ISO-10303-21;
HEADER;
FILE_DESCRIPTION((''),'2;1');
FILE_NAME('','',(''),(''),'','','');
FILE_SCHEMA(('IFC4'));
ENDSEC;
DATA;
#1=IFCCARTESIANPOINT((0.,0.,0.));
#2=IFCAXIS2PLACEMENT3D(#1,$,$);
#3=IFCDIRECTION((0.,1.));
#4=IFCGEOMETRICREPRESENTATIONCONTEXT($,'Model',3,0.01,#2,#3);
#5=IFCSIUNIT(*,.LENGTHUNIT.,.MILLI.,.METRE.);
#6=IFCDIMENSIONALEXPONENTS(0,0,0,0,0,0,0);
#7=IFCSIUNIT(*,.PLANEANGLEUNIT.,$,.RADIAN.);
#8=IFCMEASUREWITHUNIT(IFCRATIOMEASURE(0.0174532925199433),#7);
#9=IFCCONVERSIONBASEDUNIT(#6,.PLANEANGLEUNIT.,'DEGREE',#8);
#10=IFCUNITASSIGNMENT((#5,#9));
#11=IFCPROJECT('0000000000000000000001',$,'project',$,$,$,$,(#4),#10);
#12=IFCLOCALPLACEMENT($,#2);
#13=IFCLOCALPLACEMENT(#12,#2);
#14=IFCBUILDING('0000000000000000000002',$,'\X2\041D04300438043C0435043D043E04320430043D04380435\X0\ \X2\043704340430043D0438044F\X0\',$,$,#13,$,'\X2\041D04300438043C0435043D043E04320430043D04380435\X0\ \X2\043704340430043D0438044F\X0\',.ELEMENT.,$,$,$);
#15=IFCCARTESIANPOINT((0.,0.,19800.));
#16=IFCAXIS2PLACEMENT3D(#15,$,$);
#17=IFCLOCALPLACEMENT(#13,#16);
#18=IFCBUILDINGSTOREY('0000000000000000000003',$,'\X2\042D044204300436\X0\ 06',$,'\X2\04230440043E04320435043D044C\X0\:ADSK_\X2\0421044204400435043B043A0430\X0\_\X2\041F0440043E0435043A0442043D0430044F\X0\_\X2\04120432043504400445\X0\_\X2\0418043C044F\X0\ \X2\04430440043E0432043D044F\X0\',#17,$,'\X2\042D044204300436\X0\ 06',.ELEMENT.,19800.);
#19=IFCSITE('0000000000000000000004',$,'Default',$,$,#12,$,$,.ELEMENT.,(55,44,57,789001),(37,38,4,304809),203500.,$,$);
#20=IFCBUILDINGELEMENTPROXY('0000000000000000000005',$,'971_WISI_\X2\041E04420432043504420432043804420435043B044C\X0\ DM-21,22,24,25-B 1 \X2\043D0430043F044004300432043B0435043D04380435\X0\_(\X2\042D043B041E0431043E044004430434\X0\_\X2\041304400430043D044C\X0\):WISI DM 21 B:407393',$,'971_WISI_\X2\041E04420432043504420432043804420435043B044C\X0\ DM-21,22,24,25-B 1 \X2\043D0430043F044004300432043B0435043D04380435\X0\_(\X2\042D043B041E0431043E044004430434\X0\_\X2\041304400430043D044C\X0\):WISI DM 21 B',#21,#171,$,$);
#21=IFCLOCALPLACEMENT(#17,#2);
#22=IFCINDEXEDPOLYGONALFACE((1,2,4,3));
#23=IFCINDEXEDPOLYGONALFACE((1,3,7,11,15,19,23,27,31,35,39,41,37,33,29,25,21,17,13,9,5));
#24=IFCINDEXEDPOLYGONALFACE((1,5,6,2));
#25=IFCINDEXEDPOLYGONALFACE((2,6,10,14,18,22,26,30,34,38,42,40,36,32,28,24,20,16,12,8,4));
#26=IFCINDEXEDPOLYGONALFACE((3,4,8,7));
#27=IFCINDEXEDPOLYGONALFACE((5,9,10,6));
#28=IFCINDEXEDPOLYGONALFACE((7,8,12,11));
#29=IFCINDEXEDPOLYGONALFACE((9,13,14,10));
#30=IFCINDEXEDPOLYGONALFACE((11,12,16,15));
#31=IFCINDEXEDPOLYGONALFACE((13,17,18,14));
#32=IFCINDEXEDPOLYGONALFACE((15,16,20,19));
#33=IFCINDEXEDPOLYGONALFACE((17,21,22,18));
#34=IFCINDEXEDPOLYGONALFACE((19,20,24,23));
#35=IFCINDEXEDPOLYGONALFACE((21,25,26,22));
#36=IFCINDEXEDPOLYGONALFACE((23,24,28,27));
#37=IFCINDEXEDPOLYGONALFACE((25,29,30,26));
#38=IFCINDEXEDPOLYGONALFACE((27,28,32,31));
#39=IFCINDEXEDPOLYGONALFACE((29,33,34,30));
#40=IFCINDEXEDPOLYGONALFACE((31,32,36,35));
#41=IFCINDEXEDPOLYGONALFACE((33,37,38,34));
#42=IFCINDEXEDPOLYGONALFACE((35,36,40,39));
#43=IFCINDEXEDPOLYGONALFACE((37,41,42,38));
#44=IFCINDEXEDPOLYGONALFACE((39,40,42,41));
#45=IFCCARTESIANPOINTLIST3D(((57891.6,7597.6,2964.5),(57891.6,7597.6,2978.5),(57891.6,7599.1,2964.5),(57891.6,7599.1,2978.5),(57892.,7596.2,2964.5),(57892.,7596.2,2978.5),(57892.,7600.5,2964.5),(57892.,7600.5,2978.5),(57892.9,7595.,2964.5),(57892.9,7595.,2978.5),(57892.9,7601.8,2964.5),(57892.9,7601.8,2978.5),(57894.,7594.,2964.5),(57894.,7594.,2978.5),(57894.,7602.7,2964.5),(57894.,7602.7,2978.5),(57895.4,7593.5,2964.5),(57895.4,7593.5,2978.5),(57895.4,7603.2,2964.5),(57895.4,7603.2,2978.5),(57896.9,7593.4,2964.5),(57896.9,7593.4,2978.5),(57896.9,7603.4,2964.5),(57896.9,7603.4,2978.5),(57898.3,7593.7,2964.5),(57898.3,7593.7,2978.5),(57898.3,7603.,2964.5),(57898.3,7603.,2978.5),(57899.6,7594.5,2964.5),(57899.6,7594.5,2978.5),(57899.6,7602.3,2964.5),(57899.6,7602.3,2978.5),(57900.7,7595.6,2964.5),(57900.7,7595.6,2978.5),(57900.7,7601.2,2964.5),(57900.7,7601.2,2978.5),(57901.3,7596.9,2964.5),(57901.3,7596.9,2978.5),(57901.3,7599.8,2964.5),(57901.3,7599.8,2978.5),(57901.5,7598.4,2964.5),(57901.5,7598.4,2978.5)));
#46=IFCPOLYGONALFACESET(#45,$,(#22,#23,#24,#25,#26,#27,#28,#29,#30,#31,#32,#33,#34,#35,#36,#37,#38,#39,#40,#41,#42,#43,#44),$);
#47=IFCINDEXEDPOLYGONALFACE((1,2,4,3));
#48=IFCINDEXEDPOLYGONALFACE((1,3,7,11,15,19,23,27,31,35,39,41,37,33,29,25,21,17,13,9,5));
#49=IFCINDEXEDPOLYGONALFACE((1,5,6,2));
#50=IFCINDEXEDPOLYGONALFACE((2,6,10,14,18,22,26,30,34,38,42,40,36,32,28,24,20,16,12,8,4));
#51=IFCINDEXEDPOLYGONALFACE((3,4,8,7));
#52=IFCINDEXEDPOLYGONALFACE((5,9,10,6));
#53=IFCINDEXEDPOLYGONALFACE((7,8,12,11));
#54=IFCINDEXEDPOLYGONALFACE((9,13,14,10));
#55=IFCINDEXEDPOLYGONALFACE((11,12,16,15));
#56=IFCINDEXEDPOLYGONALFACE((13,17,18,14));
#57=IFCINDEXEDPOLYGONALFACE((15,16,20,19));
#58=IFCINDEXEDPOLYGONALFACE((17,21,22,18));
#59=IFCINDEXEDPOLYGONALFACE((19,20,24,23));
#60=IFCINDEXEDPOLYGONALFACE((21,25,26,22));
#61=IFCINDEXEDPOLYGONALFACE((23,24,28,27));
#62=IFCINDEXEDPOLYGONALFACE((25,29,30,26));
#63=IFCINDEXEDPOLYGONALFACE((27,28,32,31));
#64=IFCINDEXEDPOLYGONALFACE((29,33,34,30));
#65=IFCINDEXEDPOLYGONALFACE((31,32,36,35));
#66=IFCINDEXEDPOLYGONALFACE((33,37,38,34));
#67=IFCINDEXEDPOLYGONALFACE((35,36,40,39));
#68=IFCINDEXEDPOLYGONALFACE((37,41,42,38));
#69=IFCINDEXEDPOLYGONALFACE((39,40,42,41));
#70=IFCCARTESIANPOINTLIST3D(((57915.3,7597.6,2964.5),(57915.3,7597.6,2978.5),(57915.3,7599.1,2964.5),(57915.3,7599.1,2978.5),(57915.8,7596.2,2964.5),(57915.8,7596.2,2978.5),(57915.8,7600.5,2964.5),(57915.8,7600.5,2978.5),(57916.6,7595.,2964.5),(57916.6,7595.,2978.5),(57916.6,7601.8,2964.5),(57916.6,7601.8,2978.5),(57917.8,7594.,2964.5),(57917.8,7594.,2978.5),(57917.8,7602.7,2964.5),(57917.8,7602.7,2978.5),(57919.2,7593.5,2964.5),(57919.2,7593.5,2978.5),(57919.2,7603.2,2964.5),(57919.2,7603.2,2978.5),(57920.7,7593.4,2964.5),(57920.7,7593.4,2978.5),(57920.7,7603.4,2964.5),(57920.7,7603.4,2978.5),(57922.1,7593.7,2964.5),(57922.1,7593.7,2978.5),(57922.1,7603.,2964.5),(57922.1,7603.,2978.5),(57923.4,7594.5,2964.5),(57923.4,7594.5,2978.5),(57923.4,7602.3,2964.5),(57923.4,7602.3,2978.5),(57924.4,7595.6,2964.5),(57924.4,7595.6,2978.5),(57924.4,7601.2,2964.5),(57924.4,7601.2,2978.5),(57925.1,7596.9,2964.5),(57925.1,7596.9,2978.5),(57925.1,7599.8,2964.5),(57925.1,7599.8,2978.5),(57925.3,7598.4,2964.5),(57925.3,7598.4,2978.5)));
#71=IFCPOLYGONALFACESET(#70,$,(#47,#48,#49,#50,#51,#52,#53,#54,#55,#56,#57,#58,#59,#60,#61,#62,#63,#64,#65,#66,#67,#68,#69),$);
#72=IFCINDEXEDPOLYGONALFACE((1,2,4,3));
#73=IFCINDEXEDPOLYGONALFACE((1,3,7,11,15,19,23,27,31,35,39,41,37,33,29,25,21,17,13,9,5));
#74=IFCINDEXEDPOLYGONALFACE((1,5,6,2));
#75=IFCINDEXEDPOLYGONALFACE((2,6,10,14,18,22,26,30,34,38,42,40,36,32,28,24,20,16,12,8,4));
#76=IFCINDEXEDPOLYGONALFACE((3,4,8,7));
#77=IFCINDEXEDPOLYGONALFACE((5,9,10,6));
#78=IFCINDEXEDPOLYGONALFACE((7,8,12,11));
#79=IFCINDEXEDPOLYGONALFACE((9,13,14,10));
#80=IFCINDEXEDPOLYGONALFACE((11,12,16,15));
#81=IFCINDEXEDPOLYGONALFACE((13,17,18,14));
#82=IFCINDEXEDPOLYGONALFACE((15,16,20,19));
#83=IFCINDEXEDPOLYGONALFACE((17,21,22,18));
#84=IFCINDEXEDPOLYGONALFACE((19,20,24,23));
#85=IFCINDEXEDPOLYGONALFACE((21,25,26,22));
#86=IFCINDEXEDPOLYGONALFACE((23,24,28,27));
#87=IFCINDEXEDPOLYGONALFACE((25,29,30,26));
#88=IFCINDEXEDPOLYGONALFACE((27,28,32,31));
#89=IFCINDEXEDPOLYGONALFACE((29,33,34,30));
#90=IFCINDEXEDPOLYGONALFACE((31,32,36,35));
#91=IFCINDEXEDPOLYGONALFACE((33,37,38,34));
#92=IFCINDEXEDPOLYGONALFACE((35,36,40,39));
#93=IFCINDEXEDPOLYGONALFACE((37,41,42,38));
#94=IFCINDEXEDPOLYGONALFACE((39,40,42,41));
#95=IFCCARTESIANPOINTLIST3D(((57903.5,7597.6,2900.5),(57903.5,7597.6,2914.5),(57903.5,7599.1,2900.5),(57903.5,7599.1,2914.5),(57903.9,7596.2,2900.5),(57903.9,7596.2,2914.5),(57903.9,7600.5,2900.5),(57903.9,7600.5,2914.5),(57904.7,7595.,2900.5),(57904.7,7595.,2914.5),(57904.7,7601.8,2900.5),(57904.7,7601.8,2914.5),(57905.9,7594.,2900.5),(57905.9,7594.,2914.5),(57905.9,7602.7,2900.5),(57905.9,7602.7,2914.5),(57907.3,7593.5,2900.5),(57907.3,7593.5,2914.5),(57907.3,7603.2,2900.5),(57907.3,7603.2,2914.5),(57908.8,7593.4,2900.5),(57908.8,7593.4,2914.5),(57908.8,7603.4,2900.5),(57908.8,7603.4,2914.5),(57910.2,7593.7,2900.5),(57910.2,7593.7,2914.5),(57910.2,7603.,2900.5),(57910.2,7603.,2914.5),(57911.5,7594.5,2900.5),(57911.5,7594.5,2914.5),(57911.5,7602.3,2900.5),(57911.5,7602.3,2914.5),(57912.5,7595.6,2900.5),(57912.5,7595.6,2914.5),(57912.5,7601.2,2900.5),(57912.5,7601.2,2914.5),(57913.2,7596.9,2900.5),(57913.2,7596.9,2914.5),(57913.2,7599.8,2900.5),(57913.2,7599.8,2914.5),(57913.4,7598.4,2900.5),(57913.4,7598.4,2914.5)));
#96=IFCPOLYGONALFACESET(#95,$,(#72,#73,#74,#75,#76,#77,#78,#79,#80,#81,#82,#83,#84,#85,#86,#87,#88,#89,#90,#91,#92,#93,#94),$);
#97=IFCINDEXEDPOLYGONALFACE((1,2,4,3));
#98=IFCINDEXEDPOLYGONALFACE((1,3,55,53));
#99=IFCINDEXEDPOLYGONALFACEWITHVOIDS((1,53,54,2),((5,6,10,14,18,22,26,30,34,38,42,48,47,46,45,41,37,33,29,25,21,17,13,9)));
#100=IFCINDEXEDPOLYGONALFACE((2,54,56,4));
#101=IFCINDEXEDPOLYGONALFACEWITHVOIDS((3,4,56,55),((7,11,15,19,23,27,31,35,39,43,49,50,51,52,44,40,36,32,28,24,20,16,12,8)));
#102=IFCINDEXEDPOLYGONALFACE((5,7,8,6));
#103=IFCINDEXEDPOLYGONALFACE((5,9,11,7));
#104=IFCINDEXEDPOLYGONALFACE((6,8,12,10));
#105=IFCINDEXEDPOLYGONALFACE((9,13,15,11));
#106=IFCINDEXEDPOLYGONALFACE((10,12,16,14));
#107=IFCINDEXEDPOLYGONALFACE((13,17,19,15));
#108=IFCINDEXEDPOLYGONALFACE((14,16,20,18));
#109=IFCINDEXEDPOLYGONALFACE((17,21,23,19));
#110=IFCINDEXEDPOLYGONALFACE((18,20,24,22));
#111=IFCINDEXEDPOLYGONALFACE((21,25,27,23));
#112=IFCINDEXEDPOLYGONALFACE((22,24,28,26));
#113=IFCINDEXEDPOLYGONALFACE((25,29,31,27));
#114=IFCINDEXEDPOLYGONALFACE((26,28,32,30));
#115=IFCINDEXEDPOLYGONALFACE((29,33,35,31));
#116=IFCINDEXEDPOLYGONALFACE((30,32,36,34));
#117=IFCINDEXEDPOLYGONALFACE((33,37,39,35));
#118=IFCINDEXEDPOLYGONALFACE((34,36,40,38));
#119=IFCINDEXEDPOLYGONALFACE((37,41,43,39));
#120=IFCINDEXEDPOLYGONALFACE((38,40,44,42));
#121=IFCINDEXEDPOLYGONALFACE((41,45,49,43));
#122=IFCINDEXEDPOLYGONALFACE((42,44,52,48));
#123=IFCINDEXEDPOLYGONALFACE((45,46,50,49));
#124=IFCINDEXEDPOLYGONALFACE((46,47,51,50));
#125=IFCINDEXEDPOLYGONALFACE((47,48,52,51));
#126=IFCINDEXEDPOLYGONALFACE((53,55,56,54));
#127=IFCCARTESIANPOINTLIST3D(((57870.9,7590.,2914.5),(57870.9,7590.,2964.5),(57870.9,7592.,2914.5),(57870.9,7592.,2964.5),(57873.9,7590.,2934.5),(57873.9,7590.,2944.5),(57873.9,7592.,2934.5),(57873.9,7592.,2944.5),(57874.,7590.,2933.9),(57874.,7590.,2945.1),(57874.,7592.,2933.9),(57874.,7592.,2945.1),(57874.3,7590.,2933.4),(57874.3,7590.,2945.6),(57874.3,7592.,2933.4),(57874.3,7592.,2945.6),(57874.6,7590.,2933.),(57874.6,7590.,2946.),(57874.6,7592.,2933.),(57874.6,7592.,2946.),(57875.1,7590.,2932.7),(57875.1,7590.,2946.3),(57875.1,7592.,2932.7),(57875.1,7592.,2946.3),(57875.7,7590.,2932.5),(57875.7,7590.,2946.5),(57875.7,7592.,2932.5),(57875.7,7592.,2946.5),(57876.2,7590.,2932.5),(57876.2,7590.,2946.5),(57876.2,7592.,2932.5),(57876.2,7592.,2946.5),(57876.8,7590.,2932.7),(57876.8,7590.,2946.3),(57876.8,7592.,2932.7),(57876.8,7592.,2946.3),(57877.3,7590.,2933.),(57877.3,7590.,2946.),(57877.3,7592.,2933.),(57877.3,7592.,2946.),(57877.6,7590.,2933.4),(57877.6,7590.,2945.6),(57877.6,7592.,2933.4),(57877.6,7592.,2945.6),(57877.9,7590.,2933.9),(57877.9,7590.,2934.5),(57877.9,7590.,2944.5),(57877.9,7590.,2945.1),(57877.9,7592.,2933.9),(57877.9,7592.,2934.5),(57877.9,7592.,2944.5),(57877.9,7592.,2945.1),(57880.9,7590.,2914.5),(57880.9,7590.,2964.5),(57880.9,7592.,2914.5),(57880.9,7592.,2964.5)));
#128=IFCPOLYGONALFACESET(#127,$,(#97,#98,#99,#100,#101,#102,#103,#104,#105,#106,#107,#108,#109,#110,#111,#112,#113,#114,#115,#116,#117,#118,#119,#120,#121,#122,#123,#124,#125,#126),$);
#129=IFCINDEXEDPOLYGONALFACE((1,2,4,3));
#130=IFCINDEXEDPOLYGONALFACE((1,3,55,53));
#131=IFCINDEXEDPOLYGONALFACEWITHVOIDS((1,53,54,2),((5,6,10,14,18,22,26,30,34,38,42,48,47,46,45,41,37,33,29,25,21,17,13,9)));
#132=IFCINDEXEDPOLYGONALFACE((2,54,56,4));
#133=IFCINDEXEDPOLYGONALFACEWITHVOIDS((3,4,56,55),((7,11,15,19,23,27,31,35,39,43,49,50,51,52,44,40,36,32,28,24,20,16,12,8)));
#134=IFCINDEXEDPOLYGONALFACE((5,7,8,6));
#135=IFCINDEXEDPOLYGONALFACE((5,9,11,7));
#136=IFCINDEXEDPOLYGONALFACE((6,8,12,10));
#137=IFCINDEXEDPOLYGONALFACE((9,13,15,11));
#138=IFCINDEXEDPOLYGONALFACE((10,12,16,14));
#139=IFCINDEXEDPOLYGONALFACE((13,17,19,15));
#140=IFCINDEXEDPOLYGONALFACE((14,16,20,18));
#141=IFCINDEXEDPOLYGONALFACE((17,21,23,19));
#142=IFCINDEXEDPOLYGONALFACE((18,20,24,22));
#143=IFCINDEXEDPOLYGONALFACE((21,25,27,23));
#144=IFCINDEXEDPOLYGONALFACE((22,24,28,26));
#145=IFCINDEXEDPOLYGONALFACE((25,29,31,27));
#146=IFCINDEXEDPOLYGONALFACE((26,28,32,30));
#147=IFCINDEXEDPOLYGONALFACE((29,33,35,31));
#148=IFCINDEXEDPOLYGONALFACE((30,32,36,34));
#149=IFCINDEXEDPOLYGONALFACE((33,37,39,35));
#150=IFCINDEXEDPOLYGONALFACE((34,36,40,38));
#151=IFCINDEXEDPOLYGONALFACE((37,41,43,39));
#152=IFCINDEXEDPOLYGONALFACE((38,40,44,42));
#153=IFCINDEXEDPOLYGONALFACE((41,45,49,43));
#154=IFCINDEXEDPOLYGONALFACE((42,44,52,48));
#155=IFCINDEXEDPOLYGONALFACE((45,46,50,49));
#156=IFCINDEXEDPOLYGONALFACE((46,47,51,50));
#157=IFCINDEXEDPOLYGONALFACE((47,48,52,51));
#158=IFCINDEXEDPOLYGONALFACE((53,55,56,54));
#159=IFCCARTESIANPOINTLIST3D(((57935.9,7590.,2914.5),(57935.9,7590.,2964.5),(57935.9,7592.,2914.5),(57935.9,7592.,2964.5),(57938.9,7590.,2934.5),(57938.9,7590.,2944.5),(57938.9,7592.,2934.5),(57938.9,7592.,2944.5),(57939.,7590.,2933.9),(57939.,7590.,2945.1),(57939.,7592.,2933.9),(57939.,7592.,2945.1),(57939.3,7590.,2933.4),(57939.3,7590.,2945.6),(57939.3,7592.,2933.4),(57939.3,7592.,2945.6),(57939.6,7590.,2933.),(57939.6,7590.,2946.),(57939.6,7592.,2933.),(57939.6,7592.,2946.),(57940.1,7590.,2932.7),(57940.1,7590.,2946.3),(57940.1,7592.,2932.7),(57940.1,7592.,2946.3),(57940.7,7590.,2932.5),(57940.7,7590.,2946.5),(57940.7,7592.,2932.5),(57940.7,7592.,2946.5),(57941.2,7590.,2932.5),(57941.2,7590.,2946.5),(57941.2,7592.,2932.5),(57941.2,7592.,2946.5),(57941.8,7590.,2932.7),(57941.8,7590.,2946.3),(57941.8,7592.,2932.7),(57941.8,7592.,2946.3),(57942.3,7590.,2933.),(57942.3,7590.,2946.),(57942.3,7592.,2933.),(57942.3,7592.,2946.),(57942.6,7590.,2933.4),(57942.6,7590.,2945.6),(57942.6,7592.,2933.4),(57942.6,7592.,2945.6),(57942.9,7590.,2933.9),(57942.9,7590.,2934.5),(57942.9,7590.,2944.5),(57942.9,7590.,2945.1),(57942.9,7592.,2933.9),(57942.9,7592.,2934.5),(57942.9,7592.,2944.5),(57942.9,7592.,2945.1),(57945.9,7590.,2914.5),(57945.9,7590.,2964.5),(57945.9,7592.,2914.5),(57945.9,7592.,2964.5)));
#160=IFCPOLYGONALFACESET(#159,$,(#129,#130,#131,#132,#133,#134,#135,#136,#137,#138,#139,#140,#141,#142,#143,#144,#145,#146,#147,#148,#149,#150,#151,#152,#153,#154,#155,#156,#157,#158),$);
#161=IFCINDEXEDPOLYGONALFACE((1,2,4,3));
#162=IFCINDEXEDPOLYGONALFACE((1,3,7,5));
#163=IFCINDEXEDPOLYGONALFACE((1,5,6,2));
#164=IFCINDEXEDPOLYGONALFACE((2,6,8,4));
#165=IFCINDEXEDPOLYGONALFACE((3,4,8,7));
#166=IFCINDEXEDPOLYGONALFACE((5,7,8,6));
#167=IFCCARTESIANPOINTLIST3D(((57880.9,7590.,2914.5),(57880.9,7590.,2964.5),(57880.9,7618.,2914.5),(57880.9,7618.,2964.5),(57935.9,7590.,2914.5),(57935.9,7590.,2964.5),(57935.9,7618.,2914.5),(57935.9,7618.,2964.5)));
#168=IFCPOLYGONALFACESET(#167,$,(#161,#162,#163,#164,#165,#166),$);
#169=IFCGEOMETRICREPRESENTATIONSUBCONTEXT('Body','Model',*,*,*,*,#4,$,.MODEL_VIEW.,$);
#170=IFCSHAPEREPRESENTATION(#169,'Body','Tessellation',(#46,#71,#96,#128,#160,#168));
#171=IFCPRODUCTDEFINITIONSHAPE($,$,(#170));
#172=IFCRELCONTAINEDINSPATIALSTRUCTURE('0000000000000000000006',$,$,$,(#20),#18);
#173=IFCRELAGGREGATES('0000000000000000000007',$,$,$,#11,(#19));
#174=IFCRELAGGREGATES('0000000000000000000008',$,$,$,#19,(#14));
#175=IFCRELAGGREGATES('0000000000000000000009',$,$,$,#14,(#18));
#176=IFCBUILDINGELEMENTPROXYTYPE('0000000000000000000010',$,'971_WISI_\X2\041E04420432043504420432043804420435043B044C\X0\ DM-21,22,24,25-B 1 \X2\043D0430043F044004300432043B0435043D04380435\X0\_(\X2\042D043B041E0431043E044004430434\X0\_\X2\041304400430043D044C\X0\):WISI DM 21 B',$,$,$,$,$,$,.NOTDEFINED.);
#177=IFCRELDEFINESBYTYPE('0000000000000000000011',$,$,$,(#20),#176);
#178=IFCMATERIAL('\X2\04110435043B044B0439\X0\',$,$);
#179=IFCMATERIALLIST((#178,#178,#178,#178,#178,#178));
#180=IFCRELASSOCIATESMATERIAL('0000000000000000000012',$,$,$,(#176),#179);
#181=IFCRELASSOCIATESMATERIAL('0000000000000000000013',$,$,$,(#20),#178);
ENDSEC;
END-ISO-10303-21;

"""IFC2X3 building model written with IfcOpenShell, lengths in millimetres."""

from ifc_helpers import new_model, entity, si_unit, converted_unit, direction, frame, frame_2d, origin, place, context, subcontext, project, spatial, polyline, circle_curve, parameter, trimmed, segment, composite_curve, rectangle, circle, outline, extrude, source, transform, mapped, material, material_list, type_object, type_shapes, element, save


model = new_model("IFC2X3")

# Units and contexts
model_context = context("Model", 3, precision=0.01, world=origin(), true_north=direction((0.0, 1.0)))
body_context = subcontext(model_context, "Body", "Model", "MODEL_VIEW")
ifc_project = project(units=[si_unit("LENGTHUNIT", "METRE", prefix="MILLI"), converted_unit("PLANEANGLEUNIT", "DEGREE", entity("IfcRatioMeasure", 0.0174532925199433), si_unit("PLANEANGLEUNIT", "RADIAN"), dimensions=[0, 0, 0, 0, 0, 0, 0])], contexts=[model_context])

# Site, building, storey
site_placement = place(None, frame((0.0, 0.0, 0.0)))
site = spatial("IfcSite", under=ifc_project, at=site_placement, Name="Default", CompositionType="ELEMENT", RefLatitude=(55, 44, 57, 789001), RefLongitude=(37, 38, 4, 304809), RefElevation=203500.0)
building_placement = place(site_placement, origin())
building = spatial("IfcBuilding", under=site, at=building_placement, Name="Наименование здания", LongName="Наименование здания", CompositionType="ELEMENT")
storey_placement = place(building_placement, frame((0.0, 0.0, 19800.0)))
storey = spatial("IfcBuildingStorey", under=building, at=storey_placement, Name="Этаж 06", ObjectType="Уровень:ADSK_Стрелка_Проектная_Вверх_Имя уровня", LongName="Этаж 06", CompositionType="ELEMENT", Elevation=19800.0)

# Building element proxy
ifc_material_1 = material(Name="Белый")
ifc_material_list_1 = material_list([ifc_material_1, ifc_material_1, ifc_material_1, ifc_material_1, ifc_material_1, ifc_material_1])
building_element_proxy_type_1 = type_object("IfcBuildingElementProxyType", Name="971_WISI_Ответвитель DM-21,22,24,25-B 1 направление_(ЭлОборуд_Грань):WISI DM 21 B", PredefinedType="NOTDEFINED", material=ifc_material_list_1)
shared_shape_1 = source(origin(), body_context, "Body", "SweptSolid", [
    extrude(circle(Radius=5.0, at=frame_2d((0.0, 0.0), x_axis=(1.0, 0.0))), frame((11.9, 25.0, 8.4), z_axis=(0.0, 1.0, 0.0), x_axis=(-1.0, 0.0, 0.0)), (0.0, 0.0, 1.0), 14.0),
    extrude(circle(Radius=5.0, at=frame_2d((0.0, 0.0), x_axis=(1.0, 0.0))), frame((-11.8, 25.0, 8.4), z_axis=(0.0, 1.0, 0.0), x_axis=(-1.0, 0.0, 0.0)), (0.0, 0.0, 1.0), 14.0),
    extrude(circle(Radius=5.0, at=frame_2d((0.0, 0.0), x_axis=(1.0, 0.0))), frame((0.0, -39.0, 8.4), z_axis=(0.0, 1.0, 0.0), x_axis=(-1.0, 0.0, 0.0)), (0.0, 0.0, 1.0), 14.0),
    extrude(outline(polyline([(-5.0, -25.0), (5.0, -25.0), (5.0, 25.0), (-5.0, 25.0), (-5.0, -25.0)]), holes=[composite_curve([segment(polyline([(2.0, 5.0), (2.0, -5.0)]), True, "CONTINUOUS"), segment(trimmed(circle_curve(frame_2d((0.0, -5.0), x_axis=(-1.0, 0.0)), 2.0), [parameter(0.0)], [parameter(180.0)], True, "PARAMETER"), False, "CONTINUOUS"), segment(polyline([(-2.0, -5.0), (-2.0, 5.0)]), True, "CONTINUOUS"), segment(trimmed(circle_curve(frame_2d((0.0, 5.0), x_axis=(-1.0, 0.0)), 2.0), [parameter(180.0)], [parameter(0.0)], True, "PARAMETER"), False, "CONTINUOUS")], self_intersect=False)]), frame((32.5, 0.0, 0.0), z_axis=(0.0, 0.0, 1.0), x_axis=(-1.0, 0.0, 0.0)), (0.0, 0.0, 1.0), 2.0),
    extrude(outline(polyline([(-5.0, -25.0), (5.0, -25.0), (5.0, 25.0), (-5.0, 25.0), (-5.0, -25.0)]), holes=[composite_curve([segment(polyline([(-2.0, -5.0), (-2.0, 5.0)]), True, "CONTINUOUS"), segment(trimmed(circle_curve(frame_2d((0.0, 5.0), x_axis=(-1.0, 0.0)), 2.0), [parameter(180.0)], [parameter(0.0)], True, "PARAMETER"), False, "CONTINUOUS"), segment(polyline([(2.0, 5.0), (2.0, -5.0)]), True, "CONTINUOUS"), segment(trimmed(circle_curve(frame_2d((0.0, -5.0), x_axis=(-1.0, 0.0)), 2.0), [parameter(0.0)], [parameter(180.0)], True, "PARAMETER"), False, "CONTINUOUS")], self_intersect=False)]), frame((-32.5, 0.0, 0.0), z_axis=(0.0, 0.0, 1.0), x_axis=(-1.0, 0.0, 0.0)), (0.0, 0.0, 1.0), 2.0),
    extrude(rectangle(XDim=55.0, YDim=50.0, at=frame_2d((0.0, 0.0), x_axis=(1.0, 0.0))), frame((0.0, 0.0, 0.0), z_axis=(0.0, 0.0, 1.0), x_axis=(-1.0, 0.0, 0.0)), (0.0, 0.0, 1.0), 28.0),
])
type_shapes(building_element_proxy_type_1, [shared_shape_1])
for number, where, z_axis, x_axis, name in (
    (1, (57908.4, 7590.0, 2939.5), (0.0, 1.0, 0.0), (-1.0, 0.0, 0.0), "971_WISI_Ответвитель DM-21,22,24,25-B 1 направление_(ЭлОборуд_Грань):WISI DM 21 B:407393"),
):
    element("IfcBuildingElementProxy", number, at=place(storey_placement, frame(where, z_axis=z_axis, x_axis=x_axis)), inside=storey, type_object=building_element_proxy_type_1, material=ifc_material_1, Name=name, ObjectType="971_WISI_Ответвитель DM-21,22,24,25-B 1 направление_(ЭлОборуд_Грань):WISI DM 21 B", context=body_context, shape_type="MappedRepresentation", body=[
        mapped(shared_shape_1, transform((0.0, 0.0, 0.0), scale=1.0)),
    ])

save(model, "model.ifc")
